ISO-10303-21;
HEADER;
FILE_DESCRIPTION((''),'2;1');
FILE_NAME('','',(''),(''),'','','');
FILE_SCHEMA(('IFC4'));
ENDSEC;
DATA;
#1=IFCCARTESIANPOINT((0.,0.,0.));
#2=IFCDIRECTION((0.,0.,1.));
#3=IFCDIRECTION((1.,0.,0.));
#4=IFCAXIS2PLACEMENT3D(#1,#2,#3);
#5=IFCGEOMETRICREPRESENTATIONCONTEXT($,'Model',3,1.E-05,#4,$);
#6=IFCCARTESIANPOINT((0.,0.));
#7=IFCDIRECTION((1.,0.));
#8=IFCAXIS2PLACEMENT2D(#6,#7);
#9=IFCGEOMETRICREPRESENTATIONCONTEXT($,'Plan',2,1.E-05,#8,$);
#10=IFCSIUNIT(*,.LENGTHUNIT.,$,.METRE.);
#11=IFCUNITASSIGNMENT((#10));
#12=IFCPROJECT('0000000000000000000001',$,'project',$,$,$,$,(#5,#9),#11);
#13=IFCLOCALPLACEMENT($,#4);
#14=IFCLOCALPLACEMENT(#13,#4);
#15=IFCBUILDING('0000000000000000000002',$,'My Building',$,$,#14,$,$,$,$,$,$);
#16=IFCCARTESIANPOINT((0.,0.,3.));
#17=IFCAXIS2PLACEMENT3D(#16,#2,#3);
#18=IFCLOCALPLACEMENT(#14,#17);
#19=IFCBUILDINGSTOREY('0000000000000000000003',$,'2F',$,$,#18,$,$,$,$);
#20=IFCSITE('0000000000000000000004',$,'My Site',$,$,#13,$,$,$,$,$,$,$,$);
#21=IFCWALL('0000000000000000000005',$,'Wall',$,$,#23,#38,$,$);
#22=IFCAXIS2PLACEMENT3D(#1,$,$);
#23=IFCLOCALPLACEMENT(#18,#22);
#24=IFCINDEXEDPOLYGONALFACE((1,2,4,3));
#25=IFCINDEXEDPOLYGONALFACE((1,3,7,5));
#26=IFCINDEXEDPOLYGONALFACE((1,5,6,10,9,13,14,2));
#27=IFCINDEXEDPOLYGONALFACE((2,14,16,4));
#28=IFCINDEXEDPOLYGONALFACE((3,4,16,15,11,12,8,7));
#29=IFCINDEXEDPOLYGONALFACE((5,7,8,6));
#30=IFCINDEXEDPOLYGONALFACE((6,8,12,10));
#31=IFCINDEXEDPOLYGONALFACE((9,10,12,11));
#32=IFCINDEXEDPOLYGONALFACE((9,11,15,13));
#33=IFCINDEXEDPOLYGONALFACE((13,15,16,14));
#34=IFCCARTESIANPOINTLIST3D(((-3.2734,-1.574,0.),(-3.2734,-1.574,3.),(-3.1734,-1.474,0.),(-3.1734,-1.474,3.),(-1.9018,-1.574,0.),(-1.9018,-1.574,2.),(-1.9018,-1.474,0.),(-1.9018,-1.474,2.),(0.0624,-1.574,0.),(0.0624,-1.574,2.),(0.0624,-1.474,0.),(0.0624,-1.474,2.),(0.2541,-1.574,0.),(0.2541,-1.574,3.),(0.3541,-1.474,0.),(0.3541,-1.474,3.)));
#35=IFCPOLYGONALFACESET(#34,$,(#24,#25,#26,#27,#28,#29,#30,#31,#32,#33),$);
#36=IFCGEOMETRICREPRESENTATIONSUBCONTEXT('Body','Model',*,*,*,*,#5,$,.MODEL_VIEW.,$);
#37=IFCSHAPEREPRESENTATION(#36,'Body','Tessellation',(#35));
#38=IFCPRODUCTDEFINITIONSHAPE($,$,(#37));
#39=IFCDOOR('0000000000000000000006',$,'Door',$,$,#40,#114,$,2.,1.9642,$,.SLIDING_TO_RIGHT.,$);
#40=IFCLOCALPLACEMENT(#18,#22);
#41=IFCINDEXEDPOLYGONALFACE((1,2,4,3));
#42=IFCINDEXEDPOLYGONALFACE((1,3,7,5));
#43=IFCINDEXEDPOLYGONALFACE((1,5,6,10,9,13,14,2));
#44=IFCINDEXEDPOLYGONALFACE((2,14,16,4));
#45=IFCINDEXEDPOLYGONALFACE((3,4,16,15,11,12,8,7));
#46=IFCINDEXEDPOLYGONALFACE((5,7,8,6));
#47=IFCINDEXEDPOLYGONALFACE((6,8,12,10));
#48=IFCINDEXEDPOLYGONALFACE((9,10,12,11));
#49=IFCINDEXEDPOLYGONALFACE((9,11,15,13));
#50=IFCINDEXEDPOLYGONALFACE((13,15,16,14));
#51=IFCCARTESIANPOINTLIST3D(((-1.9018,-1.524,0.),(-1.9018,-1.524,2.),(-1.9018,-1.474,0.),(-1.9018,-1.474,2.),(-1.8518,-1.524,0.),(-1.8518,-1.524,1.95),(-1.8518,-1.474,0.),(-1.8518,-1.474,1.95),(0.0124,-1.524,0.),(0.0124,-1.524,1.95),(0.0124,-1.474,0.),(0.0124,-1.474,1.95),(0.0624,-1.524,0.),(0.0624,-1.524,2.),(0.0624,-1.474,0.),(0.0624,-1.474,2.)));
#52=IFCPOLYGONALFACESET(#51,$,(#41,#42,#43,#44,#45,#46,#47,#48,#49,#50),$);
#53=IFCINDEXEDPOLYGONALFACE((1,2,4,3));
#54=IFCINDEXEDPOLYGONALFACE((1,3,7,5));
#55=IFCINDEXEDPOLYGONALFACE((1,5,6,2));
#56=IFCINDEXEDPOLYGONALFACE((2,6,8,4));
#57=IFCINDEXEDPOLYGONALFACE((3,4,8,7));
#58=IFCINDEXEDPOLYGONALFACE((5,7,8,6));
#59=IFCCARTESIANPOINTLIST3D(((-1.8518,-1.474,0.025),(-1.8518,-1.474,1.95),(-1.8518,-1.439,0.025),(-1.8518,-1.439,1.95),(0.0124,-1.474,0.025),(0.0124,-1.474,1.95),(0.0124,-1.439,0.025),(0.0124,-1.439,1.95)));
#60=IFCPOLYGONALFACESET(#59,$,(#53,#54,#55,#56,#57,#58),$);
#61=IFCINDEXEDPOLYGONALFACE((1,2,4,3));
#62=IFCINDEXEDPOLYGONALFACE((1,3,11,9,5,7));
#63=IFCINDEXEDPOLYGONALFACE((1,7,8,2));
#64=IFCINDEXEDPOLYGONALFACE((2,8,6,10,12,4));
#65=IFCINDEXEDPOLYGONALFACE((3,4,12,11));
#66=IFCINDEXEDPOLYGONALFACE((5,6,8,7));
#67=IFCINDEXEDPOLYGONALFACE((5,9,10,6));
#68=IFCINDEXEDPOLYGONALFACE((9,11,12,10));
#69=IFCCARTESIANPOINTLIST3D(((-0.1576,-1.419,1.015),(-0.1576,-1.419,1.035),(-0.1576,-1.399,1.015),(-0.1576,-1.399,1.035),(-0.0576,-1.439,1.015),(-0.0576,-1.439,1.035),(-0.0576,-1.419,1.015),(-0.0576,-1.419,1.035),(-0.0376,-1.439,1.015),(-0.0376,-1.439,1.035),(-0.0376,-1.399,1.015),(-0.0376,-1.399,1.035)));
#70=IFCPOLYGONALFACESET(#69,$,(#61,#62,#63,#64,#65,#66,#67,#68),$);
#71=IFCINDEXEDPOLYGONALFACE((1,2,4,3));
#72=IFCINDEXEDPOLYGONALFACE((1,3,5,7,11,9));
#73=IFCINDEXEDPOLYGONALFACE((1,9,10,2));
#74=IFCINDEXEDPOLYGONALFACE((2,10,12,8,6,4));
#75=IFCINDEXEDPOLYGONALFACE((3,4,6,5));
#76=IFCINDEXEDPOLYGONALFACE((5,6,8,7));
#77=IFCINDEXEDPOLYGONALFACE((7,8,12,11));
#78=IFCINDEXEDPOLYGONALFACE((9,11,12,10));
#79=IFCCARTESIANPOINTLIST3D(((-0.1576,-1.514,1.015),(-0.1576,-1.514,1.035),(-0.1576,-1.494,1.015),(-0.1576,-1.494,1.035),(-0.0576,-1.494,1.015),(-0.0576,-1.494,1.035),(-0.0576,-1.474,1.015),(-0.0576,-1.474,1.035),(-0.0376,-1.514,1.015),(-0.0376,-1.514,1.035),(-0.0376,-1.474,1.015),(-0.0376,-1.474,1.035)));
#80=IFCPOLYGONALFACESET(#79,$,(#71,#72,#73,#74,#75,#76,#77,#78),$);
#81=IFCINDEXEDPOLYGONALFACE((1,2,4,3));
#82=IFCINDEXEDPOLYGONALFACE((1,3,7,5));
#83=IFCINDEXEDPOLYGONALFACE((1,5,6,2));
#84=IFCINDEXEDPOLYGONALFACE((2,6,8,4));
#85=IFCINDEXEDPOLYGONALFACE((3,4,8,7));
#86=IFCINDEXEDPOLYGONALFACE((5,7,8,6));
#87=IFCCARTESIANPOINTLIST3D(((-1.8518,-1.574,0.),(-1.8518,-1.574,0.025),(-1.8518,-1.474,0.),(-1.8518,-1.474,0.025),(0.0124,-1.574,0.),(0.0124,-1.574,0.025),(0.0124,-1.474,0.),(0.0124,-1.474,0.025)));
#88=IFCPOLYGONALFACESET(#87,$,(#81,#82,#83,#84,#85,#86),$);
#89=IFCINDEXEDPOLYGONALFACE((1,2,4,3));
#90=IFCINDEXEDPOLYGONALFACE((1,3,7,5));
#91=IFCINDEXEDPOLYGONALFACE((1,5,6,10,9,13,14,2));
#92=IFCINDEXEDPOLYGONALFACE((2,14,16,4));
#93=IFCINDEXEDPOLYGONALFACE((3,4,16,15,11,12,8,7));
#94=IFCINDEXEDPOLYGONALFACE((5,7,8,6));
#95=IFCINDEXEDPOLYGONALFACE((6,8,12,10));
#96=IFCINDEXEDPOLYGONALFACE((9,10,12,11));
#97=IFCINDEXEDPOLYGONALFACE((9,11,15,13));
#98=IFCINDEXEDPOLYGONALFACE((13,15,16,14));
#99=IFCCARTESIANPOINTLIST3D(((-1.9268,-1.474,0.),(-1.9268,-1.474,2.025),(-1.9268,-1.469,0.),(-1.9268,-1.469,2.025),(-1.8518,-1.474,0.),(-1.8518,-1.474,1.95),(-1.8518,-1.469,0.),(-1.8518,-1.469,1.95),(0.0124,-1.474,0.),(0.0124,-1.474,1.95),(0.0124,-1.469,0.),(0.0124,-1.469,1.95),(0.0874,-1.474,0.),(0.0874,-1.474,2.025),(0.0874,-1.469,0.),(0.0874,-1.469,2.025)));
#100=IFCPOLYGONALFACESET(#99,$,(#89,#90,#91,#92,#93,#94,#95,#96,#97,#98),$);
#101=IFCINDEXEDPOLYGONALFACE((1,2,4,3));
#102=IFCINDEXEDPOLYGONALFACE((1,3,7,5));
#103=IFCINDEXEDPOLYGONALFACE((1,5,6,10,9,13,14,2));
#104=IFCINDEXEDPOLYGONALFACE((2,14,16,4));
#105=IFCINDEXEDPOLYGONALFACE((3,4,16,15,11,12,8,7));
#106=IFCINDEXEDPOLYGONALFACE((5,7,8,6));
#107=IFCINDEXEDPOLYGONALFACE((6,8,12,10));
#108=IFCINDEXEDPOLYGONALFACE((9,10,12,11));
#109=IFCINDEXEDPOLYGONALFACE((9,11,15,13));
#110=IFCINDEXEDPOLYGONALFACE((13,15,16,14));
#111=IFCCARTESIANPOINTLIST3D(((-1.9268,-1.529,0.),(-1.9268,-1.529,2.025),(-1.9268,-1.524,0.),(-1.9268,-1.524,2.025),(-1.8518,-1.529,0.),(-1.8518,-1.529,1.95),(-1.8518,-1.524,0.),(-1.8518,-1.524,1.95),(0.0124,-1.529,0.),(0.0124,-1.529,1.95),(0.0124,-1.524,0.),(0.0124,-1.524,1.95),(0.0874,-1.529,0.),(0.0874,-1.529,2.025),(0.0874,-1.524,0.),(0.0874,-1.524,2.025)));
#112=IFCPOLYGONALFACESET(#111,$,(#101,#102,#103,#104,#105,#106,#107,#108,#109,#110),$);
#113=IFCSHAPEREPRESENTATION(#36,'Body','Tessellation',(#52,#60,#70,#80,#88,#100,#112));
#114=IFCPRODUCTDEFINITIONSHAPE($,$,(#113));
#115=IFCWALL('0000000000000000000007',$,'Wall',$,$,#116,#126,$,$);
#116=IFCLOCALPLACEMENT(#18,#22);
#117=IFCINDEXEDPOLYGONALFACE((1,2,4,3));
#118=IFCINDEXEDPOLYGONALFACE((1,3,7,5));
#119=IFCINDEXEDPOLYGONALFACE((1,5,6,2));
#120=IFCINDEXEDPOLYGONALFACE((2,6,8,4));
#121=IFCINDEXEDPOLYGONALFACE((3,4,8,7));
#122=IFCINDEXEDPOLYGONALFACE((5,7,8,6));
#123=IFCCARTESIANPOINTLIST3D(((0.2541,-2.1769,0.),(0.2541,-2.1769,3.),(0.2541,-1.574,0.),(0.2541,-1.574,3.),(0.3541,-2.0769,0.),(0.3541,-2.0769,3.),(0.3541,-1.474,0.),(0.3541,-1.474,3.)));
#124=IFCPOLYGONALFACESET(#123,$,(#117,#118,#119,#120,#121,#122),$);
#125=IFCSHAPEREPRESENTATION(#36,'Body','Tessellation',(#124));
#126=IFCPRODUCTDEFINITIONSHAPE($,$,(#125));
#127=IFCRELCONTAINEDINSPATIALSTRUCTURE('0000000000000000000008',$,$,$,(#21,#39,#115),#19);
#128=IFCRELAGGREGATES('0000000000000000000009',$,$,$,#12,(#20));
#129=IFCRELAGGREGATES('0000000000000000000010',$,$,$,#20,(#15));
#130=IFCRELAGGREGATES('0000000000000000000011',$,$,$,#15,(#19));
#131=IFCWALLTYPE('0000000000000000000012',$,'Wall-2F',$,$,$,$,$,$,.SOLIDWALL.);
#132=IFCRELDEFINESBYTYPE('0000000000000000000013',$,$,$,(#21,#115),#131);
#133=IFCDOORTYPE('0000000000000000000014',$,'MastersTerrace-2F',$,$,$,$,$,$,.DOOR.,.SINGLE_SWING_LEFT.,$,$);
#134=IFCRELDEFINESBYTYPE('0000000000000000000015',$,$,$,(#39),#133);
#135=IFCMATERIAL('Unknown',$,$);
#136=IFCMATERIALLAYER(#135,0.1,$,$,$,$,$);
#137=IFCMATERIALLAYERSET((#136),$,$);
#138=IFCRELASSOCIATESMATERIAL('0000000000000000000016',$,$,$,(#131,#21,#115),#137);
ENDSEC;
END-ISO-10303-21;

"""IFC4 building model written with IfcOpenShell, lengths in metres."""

from ifc_helpers import new_model, entity, si_unit, frame, origin_with_axes, origin_2d_with_axis, place, context, subcontext, project, spatial, line, indexed_curve, outline, extrude, shape, source, transform, mapped, material, layer, layer_set, layer_usage, type_object, type_shapes, element, fill, save


model = new_model("IFC4")

# Units and contexts
model_context = context("Model", 3, precision=1e-05, world=origin_with_axes())
plan_context = context("Plan", 2, precision=1e-05, world=origin_2d_with_axis())
body_context_1 = subcontext(model_context, "Body", "Model", "MODEL_VIEW")
body_context_2 = subcontext(plan_context, "Body", "Plan", "PLAN_VIEW")
ifc_project = project(units=[si_unit("LENGTHUNIT", "METRE")], contexts=[model_context, plan_context])

# Site, building, storey
site_placement = place(None, origin_with_axes())
site = spatial("IfcSite", under=ifc_project, at=site_placement, Name="My Site")
building_placement = place(site_placement, origin_with_axes())
building = spatial("IfcBuilding", under=site, at=building_placement, Name="My Building")
storey_placement = place(building_placement, frame((0.0, 0.0, 3.0), z_axis=(0.0, 0.0, 1.0), x_axis=(1.0, 0.0, 0.0)))
storey = spatial("IfcBuildingStorey", under=building, at=storey_placement, Name="2F")

# Shared definitions
ifc_material = material(Name="Unknown")

# Wall, opening, door
ifc_layer_1 = layer(ifc_material, 0.1)
ifc_layer_set_1 = layer_set([ifc_layer_1])
ifc_layer_usage_1 = layer_usage(ifc_layer_set_1, "AXIS2", "POSITIVE", 0.0)
wall_type_1 = type_object("IfcWallType", Name="Wall-2F", PredefinedType="SOLIDWALL", material=ifc_layer_set_1)
wall_1_placement = place(storey_placement, frame((-3.2734, -1.574, 0.0), z_axis=(0.0, 0.0, 1.0), x_axis=(1.0, 0.0, 0.0)))
wall_1 = element("IfcWall", 1, at=wall_1_placement, inside=storey, type_object=wall_type_1, material=ifc_layer_usage_1, Name="Wall", context=body_context_1, shape_type="SweptSolid", body=[
    extrude(outline(indexed_curve([(0.0, 0.0), (0.1, 0.1), (3.6275, 0.1), (3.5275, 0.0)], segments=[line(1, 2, 3, 4, 1)])), origin_with_axes(), (0.0, 0.0, 1.0), 3.0),
])
shared_shape_1 = source(origin_with_axes(), body_context_1, "Body", "SweptSolid", [
    extrude(outline(indexed_curve([(0.0, 0.0), (1.9642, 0.0), (1.9642, 2.0), (0.0, 2.0)], segments=[line(1, 2, 3, 4, 1)])), frame((0.0, -0.6, 0.0), z_axis=(0.0, -1.0, 0.0), x_axis=(1.0, 0.0, 0.0)), (0.0, 0.0, -1.0), 1.2),
])
opening_1_placement = place(wall_1_placement, frame((3.3358, 0.1, 0.0), z_axis=(0.0, 0.0, 1.0), x_axis=(-1.0, 0.0, 0.0)))
opening_1 = element("IfcOpeningElement", 2, at=opening_1_placement, cuts=wall_1, PredefinedType="OPENING", context=body_context_1, shape_type="MappedRepresentation", body=[
    mapped(shared_shape_1, transform((0.0, 0.0, 0.0), x_axis=(1.0, 0.0, 0.0), y_axis=(0.0, 1.0, 0.0), z_axis=(0.0, 0.0, 1.0), scale=1.0)),
])
door_type_1 = type_object("IfcDoorType", Name="MastersTerrace-2F", OperationType="SINGLE_SWING_LEFT", PredefinedType="DOOR")
shared_shape_2 = source(origin_with_axes(), body_context_1, "Body", "SweptSolid", [
    extrude(outline(indexed_curve([(0.0, 0.0), (0.0, 2.0), (1.9642, 2.0), (1.9642, 0.0), (1.9142, 0.0), (1.9142, 1.95), (0.05, 1.95), (0.05, 0.0)], segments=[line(1, 2, 3, 4, 5, 6, 7, 8, 1)])), frame((0.0, 0.0, 0.0), z_axis=(0.0, -1.0, 0.0), x_axis=(1.0, 0.0, 0.0)), (0.0, 0.0, -1.0), 0.05),
    extrude(outline(indexed_curve([(0.0, 0.0), (1.8642, 0.0), (1.8642, 0.035), (0.0, 0.035)], segments=[line(1, 2, 3, 4, 1)])), frame((0.05, -0.035, 0.025), z_axis=(0.0, 0.0, 1.0), x_axis=(1.0, 0.0, 0.0)), (0.0, 0.0, 1.0), 1.925),
    extrude(outline(indexed_curve([(0.0, 0.0), (0.0, -0.04), (0.12, -0.04), (0.12, -0.02), (0.02, -0.02), (0.02, 0.0)], segments=[line(1, 2, 3, 4, 5, 6, 1)])), frame((0.1, -0.035, 1.015), z_axis=(0.0, 0.0, 1.0), x_axis=(1.0, 0.0, 0.0)), (0.0, 0.0, 1.0), 0.02),
    extrude(outline(indexed_curve([(0.0, 0.0), (0.0, 0.04), (0.12, 0.04), (0.12, 0.02), (0.02, 0.02), (0.02, 0.0)], segments=[line(1, 2, 3, 4, 5, 6, 1)])), frame((0.1, 0.0, 1.015), z_axis=(0.0, 0.0, 1.0), x_axis=(1.0, 0.0, 0.0)), (0.0, 0.0, 1.0), 0.02),
    extrude(outline(indexed_curve([(0.0, 0.0), (1.8642, 0.0), (1.8642, 0.1), (0.0, 0.1)], segments=[line(1, 2, 3, 4, 1)])), frame((0.05, 0.0, 0.0), z_axis=(0.0, 0.0, 1.0), x_axis=(1.0, 0.0, 0.0)), (0.0, 0.0, 1.0), 0.025),
    extrude(outline(indexed_curve([(0.0, 0.0), (0.0, 2.025), (2.0142, 2.025), (2.0142, 0.0), (1.9392, 0.0), (1.9392, 1.95), (0.075, 1.95), (0.075, 0.0)], segments=[line(1, 2, 3, 4, 5, 6, 7, 8, 1)])), frame((-0.025, -0.005, 0.0), z_axis=(0.0, -1.0, 0.0), x_axis=(1.0, 0.0, 0.0)), (0.0, 0.0, -1.0), 0.005),
    extrude(outline(indexed_curve([(0.0, 0.0), (0.0, 2.025), (2.0142, 2.025), (2.0142, 0.0), (1.9392, 0.0), (1.9392, 1.95), (0.075, 1.95), (0.075, 0.0)], segments=[line(1, 2, 3, 4, 5, 6, 7, 8, 1)])), frame((-0.025, 0.05, 0.0), z_axis=(0.0, -1.0, 0.0), x_axis=(1.0, 0.0, 0.0)), (0.0, 0.0, -1.0), 0.005),
])
shared_shape_3 = source(origin_with_axes(), body_context_2, "Body", "Curve2D", [
    entity("IfcIndexedPolyCurve", entity("IfcCartesianPointList2D", [[0.0, 0.0], [0.05, 0.0], [0.05, 0.05], [0.0, 0.05]]), [entity("IfcLineIndex", [1, 2, 3, 4, 1])]),
    entity("IfcIndexedPolyCurve", entity("IfcCartesianPointList2D", [[1.9642, 0.0], [1.9142, 0.0], [1.9142, 0.05], [1.9642, 0.05]]), [entity("IfcLineIndex", [1, 2, 3, 4, 1])]),
    entity("IfcIndexedPolyCurve", entity("IfcCartesianPointList2D", [[2.8463, -0.035], [0.9821, -0.035], [0.9821, 0.0], [2.8463, 0.0]]), [entity("IfcLineIndex", [1, 2, 3, 4, 1])]),
])
type_shapes(door_type_1, [shared_shape_2, shared_shape_3])
door_1_placement = place(opening_1_placement, origin_with_axes())
door_1 = element("IfcDoor", 3, at=door_1_placement, inside=storey, type_object=door_type_1, Name="Door", OperationType="SLIDING_TO_RIGHT", OverallHeight=2.0, OverallWidth=1.9642, shapes=[
    shape(body_context_1, "Body", "MappedRepresentation", [mapped(shared_shape_2, transform((0.0, 0.0, 0.0), x_axis=(1.0, 0.0, 0.0), y_axis=(0.0, 1.0, 0.0), z_axis=(0.0, 0.0, 1.0), scale=1.0))]),
    shape(body_context_2, "Body", "MappedRepresentation", [mapped(shared_shape_3, transform((0.0, 0.0, 0.0), x_axis=(1.0, 0.0, 0.0), y_axis=(0.0, 1.0, 0.0), z_axis=(0.0, 0.0, 1.0), scale=1.0))]),
])
fill(opening_1, door_1)

# Wall
ifc_layer_usage_2 = layer_usage(ifc_layer_set_1, "AXIS2", "POSITIVE", 0.0)
wall_2_placement = place(storey_placement, frame((0.2541, -1.574, 0.0), z_axis=(0.0, 0.0, 1.0), x_axis=(0.0, -1.0, 0.0)))
element("IfcWall", 4, at=wall_2_placement, inside=storey, type_object=wall_type_1, material=ifc_layer_usage_2, Name="Wall", context=body_context_1, shape_type="SweptSolid", body=[
    extrude(outline(indexed_curve([(0.0, 0.0), (-0.1, 0.1), (0.5029, 0.1), (0.6029, 0.0)], segments=[line(1, 2, 3, 4, 1)])), origin_with_axes(), (0.0, 0.0, 1.0), 3.0),
])

save(model, "model.ifc")
